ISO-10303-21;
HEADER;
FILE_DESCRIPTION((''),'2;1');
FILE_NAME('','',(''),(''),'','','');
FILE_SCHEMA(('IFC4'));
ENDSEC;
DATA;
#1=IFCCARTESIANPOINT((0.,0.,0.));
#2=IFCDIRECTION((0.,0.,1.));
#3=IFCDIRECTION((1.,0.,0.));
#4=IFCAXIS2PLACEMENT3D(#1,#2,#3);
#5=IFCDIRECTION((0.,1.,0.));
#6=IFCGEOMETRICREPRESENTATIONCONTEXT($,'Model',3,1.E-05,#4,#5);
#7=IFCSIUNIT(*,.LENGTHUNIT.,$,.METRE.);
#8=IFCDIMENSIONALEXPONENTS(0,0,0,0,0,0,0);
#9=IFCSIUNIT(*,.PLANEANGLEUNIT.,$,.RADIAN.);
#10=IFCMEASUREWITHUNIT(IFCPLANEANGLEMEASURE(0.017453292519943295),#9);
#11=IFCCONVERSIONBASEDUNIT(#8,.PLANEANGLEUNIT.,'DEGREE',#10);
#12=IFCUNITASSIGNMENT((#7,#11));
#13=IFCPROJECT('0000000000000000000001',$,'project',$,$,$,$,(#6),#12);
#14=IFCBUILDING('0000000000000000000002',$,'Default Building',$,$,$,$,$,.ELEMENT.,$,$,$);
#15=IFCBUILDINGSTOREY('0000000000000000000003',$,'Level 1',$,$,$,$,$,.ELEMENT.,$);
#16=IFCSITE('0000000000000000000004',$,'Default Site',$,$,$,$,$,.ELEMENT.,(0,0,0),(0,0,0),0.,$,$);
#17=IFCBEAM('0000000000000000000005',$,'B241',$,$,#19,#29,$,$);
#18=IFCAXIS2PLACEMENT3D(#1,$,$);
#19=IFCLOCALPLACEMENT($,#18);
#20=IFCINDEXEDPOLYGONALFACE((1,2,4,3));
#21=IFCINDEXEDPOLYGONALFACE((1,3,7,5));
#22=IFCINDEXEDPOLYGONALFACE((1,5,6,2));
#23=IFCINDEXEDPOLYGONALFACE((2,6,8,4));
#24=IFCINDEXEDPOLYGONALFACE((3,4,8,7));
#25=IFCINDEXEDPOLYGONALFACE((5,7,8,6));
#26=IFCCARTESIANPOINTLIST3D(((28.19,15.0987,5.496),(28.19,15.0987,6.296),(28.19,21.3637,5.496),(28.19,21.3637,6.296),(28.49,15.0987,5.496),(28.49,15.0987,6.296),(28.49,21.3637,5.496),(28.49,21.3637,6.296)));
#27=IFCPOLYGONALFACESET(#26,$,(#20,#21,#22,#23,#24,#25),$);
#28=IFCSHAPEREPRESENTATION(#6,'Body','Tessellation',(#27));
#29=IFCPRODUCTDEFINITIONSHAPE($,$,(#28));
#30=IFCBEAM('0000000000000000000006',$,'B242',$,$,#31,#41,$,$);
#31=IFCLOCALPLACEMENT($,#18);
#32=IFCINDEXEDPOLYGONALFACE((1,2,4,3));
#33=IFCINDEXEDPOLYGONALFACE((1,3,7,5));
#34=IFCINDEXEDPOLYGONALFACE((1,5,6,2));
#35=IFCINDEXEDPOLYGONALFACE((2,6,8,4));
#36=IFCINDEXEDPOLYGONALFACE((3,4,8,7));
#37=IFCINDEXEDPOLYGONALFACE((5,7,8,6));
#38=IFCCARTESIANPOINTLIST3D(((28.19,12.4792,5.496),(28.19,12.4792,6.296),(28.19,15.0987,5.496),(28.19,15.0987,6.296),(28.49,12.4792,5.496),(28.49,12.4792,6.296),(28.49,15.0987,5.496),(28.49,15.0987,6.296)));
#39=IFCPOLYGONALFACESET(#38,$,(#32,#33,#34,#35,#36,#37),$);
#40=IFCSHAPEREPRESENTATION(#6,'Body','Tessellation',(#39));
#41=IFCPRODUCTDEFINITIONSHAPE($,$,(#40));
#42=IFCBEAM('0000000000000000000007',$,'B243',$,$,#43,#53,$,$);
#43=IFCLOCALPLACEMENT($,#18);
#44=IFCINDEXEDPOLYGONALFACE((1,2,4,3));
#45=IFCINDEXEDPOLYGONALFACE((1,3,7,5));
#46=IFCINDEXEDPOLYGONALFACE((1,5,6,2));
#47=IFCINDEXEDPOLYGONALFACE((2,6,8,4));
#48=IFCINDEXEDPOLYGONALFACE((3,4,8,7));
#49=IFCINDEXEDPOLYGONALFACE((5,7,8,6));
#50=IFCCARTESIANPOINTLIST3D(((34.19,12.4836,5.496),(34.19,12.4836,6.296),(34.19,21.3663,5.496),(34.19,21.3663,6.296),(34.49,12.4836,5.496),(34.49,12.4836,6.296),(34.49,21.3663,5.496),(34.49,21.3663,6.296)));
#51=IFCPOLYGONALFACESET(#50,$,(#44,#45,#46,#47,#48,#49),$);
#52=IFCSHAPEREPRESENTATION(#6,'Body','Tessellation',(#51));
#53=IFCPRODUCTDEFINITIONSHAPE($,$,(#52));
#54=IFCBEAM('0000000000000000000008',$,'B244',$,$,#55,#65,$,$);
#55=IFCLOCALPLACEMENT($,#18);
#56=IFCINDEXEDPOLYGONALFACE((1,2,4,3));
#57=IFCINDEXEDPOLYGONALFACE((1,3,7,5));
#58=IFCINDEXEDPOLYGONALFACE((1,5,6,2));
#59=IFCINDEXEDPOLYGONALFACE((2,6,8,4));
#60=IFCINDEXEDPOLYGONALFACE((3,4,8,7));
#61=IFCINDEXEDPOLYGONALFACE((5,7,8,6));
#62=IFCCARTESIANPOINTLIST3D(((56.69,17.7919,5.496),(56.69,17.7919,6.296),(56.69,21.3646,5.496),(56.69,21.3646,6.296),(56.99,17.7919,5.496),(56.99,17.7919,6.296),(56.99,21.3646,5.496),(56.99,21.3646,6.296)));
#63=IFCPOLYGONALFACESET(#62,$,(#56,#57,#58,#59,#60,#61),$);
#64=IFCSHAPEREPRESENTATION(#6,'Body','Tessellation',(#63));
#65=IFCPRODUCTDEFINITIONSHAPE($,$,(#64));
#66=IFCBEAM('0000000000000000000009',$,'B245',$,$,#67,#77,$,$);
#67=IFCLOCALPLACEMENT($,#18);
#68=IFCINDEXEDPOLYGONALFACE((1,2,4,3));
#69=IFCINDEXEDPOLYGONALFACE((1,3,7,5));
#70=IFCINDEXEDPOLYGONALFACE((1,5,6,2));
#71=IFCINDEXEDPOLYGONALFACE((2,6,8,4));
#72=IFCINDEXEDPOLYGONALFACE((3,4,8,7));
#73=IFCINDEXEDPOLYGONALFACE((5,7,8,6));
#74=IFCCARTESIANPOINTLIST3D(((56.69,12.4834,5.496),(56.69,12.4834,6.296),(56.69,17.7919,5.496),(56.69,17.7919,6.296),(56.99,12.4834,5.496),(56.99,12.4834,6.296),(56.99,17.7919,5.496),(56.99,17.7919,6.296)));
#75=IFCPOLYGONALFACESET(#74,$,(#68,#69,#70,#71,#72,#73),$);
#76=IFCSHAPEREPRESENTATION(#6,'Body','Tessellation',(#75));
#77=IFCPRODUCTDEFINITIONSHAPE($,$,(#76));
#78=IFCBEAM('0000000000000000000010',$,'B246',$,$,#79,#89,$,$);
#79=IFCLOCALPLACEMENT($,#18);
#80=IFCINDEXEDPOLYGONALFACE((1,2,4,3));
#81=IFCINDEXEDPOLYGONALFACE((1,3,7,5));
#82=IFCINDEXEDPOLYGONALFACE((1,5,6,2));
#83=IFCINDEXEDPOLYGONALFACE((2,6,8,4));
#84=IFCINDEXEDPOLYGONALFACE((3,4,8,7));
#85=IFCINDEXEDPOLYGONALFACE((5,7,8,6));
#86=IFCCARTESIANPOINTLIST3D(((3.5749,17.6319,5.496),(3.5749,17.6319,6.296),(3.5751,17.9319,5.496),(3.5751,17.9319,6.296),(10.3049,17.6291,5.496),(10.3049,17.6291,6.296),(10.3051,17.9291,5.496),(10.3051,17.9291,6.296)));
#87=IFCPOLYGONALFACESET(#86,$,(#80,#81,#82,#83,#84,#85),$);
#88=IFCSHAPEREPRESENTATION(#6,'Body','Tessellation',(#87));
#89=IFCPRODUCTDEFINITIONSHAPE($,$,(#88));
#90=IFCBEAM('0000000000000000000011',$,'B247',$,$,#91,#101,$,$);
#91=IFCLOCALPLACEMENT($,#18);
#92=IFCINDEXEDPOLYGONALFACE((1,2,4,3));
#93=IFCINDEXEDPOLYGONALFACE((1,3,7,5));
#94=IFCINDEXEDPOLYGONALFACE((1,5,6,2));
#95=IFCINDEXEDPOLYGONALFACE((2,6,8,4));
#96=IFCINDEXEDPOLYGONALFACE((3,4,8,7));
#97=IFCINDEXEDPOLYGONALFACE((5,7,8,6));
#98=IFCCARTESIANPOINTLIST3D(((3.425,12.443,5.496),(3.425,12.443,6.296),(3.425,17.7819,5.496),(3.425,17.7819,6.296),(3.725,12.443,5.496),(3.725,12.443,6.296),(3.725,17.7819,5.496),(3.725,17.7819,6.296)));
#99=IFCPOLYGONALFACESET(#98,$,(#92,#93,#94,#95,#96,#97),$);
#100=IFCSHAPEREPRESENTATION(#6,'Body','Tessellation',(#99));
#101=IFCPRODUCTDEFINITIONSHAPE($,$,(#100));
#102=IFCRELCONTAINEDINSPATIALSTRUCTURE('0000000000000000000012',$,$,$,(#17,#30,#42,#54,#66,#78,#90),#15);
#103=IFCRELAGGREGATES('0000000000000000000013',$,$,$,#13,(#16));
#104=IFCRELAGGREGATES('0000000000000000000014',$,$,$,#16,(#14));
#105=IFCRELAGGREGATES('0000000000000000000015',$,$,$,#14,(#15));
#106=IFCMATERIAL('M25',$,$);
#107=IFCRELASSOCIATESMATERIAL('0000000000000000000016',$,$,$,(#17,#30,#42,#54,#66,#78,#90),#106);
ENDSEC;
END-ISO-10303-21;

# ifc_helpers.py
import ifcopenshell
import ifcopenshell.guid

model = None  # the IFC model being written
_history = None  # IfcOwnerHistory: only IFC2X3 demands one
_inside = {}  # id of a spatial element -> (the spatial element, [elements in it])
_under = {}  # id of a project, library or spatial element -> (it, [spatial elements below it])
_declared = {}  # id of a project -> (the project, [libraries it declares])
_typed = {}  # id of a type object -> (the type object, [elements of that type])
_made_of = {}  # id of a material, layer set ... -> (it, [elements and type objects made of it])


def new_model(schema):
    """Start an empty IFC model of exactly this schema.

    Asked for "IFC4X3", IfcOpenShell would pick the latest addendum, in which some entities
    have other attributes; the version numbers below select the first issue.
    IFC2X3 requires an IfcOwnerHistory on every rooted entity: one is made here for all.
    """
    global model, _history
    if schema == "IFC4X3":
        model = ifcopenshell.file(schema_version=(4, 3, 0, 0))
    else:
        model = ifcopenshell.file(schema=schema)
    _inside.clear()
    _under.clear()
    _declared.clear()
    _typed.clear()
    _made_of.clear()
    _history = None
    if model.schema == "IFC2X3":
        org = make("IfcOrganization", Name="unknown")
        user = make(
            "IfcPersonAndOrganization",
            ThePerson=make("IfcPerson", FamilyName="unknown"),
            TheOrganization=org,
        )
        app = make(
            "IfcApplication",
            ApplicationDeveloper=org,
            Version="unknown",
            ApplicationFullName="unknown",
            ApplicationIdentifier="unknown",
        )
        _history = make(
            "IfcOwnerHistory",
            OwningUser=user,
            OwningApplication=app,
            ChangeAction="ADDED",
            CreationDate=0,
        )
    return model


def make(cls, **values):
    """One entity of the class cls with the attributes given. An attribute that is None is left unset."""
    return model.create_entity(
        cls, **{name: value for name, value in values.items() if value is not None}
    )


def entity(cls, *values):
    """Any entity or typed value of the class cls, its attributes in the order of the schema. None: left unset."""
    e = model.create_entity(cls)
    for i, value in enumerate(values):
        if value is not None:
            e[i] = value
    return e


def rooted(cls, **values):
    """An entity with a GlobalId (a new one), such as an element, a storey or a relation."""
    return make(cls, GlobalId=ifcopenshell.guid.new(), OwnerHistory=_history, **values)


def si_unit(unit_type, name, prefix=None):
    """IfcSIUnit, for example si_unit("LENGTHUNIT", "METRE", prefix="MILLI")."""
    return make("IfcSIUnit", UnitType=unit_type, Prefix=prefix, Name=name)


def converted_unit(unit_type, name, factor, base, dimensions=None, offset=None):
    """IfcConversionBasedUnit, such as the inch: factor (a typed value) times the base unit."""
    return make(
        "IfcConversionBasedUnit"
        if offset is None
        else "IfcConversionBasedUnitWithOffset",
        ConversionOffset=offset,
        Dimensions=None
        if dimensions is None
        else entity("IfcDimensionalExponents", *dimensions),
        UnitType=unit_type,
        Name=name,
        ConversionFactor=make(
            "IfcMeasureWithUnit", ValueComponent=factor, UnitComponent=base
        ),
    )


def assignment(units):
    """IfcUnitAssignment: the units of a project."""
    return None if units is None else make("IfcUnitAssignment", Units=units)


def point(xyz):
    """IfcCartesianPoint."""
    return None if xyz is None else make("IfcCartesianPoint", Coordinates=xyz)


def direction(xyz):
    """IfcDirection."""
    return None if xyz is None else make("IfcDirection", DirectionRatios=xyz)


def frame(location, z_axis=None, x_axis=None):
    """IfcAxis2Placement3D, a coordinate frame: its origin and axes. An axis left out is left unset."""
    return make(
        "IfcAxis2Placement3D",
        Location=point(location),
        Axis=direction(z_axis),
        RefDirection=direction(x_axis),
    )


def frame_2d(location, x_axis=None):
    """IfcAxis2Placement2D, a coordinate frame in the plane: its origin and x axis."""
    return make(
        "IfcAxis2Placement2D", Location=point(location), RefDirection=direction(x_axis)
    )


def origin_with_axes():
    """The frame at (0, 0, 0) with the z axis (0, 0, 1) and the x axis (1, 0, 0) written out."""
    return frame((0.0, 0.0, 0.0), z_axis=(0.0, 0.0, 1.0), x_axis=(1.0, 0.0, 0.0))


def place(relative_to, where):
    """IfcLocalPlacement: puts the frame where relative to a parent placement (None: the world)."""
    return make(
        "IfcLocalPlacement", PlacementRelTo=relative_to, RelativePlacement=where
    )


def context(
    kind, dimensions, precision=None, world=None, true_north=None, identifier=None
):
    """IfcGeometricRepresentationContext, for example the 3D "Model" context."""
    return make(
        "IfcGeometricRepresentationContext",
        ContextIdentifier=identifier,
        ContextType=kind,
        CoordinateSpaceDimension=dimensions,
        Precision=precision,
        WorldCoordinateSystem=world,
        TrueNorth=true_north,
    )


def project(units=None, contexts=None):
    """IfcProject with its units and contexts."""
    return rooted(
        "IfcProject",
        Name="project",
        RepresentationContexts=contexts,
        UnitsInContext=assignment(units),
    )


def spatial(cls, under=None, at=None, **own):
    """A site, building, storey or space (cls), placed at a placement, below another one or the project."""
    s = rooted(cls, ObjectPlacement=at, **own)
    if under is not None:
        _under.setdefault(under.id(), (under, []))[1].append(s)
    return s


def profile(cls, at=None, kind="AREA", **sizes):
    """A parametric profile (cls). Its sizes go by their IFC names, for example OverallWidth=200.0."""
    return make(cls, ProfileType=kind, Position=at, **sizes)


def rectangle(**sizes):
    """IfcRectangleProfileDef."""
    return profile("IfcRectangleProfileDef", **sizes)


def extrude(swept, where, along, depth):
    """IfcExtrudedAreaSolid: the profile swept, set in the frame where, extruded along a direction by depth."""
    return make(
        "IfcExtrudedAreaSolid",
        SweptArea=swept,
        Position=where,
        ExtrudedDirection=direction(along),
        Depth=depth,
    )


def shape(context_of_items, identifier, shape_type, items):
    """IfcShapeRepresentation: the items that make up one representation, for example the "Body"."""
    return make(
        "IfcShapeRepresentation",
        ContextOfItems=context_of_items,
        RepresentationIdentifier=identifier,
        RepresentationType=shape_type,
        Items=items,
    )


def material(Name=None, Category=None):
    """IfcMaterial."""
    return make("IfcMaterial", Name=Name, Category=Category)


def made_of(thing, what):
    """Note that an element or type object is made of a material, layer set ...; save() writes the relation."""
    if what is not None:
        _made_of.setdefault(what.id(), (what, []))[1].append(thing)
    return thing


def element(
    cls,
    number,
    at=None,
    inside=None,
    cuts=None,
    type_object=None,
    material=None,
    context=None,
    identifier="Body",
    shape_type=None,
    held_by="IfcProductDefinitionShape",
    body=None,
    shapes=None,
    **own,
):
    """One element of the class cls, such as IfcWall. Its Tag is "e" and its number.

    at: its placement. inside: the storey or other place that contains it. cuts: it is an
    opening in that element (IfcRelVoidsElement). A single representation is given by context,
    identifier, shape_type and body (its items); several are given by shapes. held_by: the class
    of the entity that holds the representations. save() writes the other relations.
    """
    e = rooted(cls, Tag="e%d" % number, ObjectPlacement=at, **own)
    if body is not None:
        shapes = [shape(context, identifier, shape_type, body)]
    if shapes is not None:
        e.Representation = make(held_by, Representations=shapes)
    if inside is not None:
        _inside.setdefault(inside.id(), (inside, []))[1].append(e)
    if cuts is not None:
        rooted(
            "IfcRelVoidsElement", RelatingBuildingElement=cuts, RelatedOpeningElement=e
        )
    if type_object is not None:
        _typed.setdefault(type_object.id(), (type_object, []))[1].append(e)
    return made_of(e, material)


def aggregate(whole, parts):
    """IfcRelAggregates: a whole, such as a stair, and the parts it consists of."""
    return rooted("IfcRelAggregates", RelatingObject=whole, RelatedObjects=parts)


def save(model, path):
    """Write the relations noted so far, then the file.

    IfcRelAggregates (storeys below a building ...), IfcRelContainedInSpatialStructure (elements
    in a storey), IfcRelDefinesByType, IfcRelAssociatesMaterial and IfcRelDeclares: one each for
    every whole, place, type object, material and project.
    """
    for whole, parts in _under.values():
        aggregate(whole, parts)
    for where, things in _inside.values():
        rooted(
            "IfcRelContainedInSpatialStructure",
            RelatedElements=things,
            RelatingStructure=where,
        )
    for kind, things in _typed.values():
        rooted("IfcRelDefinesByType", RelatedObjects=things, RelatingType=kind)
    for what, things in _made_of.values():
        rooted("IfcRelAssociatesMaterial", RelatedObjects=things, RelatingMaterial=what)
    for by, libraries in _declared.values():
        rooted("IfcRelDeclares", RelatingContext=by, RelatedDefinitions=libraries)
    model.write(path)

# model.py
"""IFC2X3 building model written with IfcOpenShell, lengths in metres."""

from ifc_helpers import new_model, entity, si_unit, converted_unit, direction, frame, frame_2d, origin_with_axes, place, context, project, spatial, rectangle, extrude, material, element, save


model = new_model("IFC2X3")

# Units and contexts
model_context = context("Model", 3, precision=1e-05, world=origin_with_axes(), true_north=direction((0.0, 1.0, 0.0)))
ifc_project = project(units=[si_unit("LENGTHUNIT", "METRE"), converted_unit("PLANEANGLEUNIT", "DEGREE", entity("IfcPlaneAngleMeasure", 0.017453292519943295), si_unit("PLANEANGLEUNIT", "RADIAN"), dimensions=[0, 0, 0, 0, 0, 0, 0])], contexts=[model_context])

# Site, building, storey
site = spatial("IfcSite", under=ifc_project, Name="Default Site", CompositionType="ELEMENT", RefLatitude=(0, 0, 0), RefLongitude=(0, 0, 0), RefElevation=0.0)
building = spatial("IfcBuilding", under=site, Name="Default Building", CompositionType="ELEMENT")
storey = spatial("IfcBuildingStorey", under=building, Name="Level 1", CompositionType="ELEMENT")

# Beams
ifc_material = material(Name="M25")
placement = place(None, origin_with_axes())
element("IfcBeam", 1, at=placement, inside=storey, material=ifc_material, Name="B241", context=model_context, shape_type="SweptSolid", body=[
    extrude(rectangle(XDim=0.3, YDim=0.8, at=frame_2d((0.0, 0.0), x_axis=(0.0, 1.0, 0.0))), frame((28.34, 21.3637, 5.896), z_axis=(0.0, -1.0, 0.0), x_axis=(0.0, 0.0, -1.0)), (0.0, 0.0, 1.0), 6.265),
])
element("IfcBeam", 2, at=placement, inside=storey, material=ifc_material, Name="B242", context=model_context, shape_type="SweptSolid", body=[
    extrude(rectangle(XDim=0.3, YDim=0.8, at=frame_2d((0.0, 0.0), x_axis=(0.0, 1.0, 0.0))), frame((28.34, 15.0987, 5.896), z_axis=(0.0, -1.0, 0.0), x_axis=(0.0, 0.0, -1.0)), (0.0, 0.0, 1.0), 2.6195),
])
element("IfcBeam", 3, at=placement, inside=storey, material=ifc_material, Name="B243", context=model_context, shape_type="SweptSolid", body=[
    extrude(rectangle(XDim=0.3, YDim=0.8, at=frame_2d((0.0, 0.0), x_axis=(0.0, 1.0, 0.0))), frame((34.34, 12.4836, 5.896), z_axis=(0.0, 1.0, 0.0), x_axis=(0.0, 0.0, -1.0)), (0.0, 0.0, 1.0), 8.8827),
])
element("IfcBeam", 4, at=placement, inside=storey, material=ifc_material, Name="B244", context=model_context, shape_type="SweptSolid", body=[
    extrude(rectangle(XDim=0.3, YDim=0.8, at=frame_2d((0.0, 0.0), x_axis=(0.0, 1.0, 0.0))), frame((56.84, 17.7919, 5.896), z_axis=(0.0, 1.0, 0.0), x_axis=(0.0, 0.0, -1.0)), (0.0, 0.0, 1.0), 3.5727),
])
element("IfcBeam", 5, at=placement, inside=storey, material=ifc_material, Name="B245", context=model_context, shape_type="SweptSolid", body=[
    extrude(rectangle(XDim=0.3, YDim=0.8, at=frame_2d((0.0, 0.0), x_axis=(0.0, 1.0, 0.0))), frame((56.84, 12.4834, 5.896), z_axis=(0.0, 1.0, 0.0), x_axis=(0.0, 0.0, -1.0)), (0.0, 0.0, 1.0), 5.3085),
])
element("IfcBeam", 6, at=placement, inside=storey, material=ifc_material, Name="B246", context=model_context, shape_type="SweptSolid", body=[
    extrude(rectangle(XDim=0.3, YDim=0.8, at=frame_2d((0.0, 0.0), x_axis=(0.0, 1.0, 0.0))), frame((10.305, 17.7791, 5.896), z_axis=(-1.0, 0.000419, 0.0), x_axis=(0.0, 0.0, -1.0)), (0.0, 0.0, 1.0), 6.73),
])
element("IfcBeam", 7, at=placement, inside=storey, material=ifc_material, Name="B247", context=model_context, shape_type="SweptSolid", body=[
    extrude(rectangle(XDim=0.3, YDim=0.8, at=frame_2d((0.0, 0.0), x_axis=(0.0, 1.0, 0.0))), frame((3.575, 12.443, 5.896), z_axis=(0.0, 1.0, 0.0), x_axis=(0.0, 0.0, -1.0)), (0.0, 0.0, 1.0), 5.3389),
])

save(model, "model.ifc")
